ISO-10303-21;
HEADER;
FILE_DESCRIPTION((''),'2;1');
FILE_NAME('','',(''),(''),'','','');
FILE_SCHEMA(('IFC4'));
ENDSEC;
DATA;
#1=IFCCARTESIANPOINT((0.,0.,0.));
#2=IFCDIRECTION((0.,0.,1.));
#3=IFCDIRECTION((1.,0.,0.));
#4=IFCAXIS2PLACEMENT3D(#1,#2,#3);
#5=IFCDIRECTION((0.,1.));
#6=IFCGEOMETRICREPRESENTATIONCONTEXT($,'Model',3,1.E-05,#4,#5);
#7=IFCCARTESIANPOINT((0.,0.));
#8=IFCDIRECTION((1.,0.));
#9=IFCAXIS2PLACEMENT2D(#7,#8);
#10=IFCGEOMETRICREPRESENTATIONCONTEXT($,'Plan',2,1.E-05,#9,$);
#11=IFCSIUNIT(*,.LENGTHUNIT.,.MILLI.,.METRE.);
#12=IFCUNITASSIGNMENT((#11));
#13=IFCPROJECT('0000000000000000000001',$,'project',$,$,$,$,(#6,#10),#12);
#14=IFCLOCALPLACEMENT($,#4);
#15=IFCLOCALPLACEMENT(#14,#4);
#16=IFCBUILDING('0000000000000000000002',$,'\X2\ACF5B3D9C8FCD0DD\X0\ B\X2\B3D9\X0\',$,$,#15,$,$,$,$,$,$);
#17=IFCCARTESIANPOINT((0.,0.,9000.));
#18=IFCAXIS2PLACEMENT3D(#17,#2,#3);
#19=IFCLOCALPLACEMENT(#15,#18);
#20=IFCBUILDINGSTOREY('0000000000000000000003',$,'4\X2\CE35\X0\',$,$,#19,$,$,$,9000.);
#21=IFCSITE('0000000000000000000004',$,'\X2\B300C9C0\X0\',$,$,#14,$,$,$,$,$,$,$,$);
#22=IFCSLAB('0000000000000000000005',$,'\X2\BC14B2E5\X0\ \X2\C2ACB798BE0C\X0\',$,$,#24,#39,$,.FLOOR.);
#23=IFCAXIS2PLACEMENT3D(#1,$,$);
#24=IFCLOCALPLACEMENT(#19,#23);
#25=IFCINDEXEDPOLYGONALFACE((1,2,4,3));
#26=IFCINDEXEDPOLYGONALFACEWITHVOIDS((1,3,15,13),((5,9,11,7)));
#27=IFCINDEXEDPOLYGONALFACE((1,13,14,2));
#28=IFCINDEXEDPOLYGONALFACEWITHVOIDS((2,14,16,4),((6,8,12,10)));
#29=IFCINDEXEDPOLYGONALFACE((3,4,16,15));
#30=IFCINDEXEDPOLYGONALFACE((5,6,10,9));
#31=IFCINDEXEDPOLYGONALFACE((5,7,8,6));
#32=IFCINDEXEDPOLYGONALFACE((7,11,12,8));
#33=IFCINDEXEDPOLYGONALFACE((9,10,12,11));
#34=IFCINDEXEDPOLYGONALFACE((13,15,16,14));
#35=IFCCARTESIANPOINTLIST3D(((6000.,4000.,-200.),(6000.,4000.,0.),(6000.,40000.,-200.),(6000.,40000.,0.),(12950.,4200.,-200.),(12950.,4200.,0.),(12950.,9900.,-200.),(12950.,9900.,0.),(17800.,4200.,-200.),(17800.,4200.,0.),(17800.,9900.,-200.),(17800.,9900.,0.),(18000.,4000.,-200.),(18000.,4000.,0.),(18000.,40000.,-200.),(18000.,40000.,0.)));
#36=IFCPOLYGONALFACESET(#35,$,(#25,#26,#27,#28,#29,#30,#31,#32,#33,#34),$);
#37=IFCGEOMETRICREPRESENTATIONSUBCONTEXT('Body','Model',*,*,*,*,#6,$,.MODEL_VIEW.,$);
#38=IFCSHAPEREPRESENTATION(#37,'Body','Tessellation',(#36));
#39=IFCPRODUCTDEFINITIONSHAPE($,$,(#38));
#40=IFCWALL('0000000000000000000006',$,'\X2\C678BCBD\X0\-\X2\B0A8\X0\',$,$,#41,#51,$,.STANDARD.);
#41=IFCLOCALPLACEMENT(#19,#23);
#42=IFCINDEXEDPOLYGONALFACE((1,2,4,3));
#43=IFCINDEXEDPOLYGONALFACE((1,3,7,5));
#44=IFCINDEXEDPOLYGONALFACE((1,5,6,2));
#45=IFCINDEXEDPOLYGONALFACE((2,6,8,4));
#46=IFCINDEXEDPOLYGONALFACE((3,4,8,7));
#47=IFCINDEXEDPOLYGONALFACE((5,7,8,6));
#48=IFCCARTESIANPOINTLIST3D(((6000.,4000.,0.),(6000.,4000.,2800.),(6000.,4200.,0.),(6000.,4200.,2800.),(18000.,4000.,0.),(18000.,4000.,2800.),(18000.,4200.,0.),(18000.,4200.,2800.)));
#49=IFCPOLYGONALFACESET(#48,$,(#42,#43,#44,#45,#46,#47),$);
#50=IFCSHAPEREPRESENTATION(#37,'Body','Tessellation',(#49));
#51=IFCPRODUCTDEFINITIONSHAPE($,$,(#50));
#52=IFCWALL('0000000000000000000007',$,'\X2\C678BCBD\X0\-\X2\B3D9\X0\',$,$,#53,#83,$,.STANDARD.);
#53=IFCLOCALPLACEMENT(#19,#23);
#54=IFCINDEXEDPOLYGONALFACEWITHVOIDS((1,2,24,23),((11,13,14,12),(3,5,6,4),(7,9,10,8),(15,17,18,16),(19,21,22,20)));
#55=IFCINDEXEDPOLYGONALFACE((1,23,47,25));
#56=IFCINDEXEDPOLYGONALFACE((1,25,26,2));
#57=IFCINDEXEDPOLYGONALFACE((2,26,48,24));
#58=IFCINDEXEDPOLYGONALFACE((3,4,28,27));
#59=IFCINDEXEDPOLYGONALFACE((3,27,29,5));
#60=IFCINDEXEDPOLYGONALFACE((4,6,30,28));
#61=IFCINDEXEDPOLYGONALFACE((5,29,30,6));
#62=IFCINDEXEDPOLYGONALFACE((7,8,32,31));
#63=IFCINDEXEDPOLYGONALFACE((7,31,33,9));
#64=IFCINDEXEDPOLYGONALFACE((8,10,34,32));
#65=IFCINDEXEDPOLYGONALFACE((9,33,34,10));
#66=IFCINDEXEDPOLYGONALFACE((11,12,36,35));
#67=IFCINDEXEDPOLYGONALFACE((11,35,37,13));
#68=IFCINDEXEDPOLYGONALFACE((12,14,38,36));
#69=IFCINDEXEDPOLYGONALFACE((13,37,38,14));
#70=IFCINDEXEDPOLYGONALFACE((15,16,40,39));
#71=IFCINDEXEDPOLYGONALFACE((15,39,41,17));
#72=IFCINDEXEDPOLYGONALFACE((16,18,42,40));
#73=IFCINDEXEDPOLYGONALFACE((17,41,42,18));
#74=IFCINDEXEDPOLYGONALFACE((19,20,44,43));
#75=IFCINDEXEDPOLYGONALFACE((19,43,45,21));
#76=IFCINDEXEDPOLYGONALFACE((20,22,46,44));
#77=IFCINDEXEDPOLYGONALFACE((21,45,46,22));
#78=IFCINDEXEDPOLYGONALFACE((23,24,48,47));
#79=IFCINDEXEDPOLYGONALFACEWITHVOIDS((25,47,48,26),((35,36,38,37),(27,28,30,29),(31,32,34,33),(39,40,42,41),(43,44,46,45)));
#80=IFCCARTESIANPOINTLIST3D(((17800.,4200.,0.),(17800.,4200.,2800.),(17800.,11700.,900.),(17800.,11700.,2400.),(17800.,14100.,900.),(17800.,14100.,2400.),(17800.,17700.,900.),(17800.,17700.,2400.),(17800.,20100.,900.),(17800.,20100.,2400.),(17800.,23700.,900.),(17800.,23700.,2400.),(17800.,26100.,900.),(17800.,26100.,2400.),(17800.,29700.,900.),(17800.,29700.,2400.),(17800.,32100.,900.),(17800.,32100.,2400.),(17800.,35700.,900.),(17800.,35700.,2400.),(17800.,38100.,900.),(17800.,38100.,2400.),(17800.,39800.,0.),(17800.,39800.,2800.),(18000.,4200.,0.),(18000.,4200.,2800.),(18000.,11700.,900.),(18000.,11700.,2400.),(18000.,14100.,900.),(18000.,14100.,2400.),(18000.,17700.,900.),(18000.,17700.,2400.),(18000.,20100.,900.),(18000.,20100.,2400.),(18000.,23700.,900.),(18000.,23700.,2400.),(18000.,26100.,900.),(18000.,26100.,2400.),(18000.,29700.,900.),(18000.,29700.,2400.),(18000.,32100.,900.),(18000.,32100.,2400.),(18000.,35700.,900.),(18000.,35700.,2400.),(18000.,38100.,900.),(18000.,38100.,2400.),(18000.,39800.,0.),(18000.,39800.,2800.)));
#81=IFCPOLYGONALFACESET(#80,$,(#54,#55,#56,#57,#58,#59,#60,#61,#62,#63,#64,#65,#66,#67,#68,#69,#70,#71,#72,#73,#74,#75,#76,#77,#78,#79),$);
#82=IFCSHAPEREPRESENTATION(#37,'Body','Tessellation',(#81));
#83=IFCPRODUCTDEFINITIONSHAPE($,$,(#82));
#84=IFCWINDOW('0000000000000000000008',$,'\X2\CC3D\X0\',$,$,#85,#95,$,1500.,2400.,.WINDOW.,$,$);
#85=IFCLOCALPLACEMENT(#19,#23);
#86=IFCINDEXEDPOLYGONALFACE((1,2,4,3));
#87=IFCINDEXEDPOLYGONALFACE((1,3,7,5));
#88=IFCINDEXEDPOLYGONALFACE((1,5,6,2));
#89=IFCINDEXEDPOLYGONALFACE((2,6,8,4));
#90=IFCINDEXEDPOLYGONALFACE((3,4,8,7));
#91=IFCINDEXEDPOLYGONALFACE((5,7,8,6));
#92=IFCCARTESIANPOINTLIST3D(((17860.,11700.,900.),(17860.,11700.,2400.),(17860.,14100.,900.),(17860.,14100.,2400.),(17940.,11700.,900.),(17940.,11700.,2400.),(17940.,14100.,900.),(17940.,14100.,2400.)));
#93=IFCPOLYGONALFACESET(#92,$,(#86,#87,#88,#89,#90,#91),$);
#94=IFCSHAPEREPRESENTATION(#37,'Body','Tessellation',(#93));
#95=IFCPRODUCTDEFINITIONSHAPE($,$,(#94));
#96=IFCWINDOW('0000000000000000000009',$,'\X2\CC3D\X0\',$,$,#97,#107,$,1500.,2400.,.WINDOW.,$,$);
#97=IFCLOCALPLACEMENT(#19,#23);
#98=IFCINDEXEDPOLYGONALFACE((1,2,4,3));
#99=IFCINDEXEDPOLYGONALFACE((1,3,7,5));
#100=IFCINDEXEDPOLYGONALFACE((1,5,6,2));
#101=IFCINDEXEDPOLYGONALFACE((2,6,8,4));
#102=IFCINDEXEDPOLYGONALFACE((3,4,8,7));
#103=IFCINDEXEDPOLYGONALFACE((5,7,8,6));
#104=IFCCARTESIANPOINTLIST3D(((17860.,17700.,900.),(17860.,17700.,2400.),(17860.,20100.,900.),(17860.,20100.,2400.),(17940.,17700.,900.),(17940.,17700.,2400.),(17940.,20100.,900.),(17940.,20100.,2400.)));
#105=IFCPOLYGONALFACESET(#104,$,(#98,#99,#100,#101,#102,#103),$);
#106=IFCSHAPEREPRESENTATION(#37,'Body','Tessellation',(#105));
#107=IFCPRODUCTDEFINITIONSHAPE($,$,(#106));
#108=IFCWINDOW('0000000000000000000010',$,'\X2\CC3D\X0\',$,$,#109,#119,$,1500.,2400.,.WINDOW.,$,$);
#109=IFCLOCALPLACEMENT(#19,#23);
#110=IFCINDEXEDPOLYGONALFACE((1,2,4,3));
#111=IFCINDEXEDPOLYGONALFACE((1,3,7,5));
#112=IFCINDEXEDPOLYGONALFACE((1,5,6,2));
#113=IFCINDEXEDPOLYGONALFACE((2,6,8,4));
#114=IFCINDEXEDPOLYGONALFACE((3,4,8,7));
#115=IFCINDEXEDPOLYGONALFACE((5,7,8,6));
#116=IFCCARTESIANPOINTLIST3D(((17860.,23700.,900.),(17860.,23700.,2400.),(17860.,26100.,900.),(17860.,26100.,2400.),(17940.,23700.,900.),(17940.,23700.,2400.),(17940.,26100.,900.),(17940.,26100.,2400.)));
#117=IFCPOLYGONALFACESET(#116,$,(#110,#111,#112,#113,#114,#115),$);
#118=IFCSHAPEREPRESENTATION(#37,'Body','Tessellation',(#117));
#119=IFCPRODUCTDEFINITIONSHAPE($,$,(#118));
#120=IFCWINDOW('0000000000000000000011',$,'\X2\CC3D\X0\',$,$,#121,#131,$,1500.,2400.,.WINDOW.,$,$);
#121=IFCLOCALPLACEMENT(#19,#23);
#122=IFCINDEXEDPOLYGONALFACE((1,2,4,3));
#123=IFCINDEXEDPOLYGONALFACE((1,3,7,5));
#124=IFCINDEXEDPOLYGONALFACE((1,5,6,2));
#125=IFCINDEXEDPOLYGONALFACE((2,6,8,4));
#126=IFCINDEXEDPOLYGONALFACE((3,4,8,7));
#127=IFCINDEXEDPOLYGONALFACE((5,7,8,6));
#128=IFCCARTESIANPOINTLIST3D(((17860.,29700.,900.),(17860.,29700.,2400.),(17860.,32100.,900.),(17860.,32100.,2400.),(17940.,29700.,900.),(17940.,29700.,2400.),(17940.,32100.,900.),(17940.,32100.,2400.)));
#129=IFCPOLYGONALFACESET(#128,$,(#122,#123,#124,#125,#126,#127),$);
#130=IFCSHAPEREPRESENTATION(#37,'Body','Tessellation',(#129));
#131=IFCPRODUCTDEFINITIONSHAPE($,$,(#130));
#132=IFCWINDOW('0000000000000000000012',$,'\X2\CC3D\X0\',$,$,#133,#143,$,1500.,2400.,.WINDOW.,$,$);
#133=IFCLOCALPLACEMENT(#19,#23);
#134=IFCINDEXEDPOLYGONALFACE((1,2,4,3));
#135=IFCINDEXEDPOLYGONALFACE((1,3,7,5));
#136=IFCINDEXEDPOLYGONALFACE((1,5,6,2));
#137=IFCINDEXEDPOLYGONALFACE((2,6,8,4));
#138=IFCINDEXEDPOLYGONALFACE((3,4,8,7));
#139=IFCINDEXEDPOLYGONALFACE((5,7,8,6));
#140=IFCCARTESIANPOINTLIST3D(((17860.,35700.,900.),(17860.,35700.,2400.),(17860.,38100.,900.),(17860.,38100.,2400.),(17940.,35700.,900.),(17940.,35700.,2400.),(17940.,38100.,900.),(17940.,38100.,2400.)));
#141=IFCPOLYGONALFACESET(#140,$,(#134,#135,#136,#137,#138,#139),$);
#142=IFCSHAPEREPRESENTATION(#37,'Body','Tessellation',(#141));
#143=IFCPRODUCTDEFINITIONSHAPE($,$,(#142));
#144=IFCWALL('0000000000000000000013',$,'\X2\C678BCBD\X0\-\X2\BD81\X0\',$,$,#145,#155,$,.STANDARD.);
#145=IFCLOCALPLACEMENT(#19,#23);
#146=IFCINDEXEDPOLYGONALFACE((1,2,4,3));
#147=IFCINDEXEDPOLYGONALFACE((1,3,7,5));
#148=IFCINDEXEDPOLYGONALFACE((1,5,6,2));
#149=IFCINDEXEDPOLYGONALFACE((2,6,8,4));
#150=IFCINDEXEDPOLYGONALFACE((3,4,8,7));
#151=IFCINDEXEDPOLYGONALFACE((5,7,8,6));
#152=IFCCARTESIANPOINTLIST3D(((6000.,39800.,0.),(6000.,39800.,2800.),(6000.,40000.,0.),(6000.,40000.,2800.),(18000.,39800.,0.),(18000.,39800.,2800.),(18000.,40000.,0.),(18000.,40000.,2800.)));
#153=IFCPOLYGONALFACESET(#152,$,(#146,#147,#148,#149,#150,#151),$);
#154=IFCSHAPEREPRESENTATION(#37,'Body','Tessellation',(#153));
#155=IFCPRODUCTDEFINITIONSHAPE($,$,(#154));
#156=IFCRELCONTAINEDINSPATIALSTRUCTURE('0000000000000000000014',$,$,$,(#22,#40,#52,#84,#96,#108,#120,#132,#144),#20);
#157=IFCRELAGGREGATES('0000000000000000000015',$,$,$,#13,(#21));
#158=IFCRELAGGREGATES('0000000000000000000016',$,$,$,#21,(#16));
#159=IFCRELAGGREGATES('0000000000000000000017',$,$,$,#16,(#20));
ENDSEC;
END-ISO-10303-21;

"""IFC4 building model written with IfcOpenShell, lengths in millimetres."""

from ifc_helpers import new_model, si_unit, direction, frame, origin_with_axes, origin_2d_with_axis, place, context, subcontext, project, spatial, polyline, outline, extrude, element, fill, save


model = new_model("IFC4")

# Units and contexts
model_context = context("Model", 3, precision=1e-05, world=origin_with_axes(), true_north=direction((0.0, 1.0)))
plan_context = context("Plan", 2, precision=1e-05, world=origin_2d_with_axis())
body_context = subcontext(model_context, "Body", "Model", "MODEL_VIEW")
ifc_project = project(units=[si_unit("LENGTHUNIT", "METRE", prefix="MILLI")], contexts=[model_context, plan_context])

# Site, building, storey
site_placement = place(None, origin_with_axes())
site = spatial("IfcSite", under=ifc_project, at=site_placement, Name="대지")
building_placement = place(site_placement, origin_with_axes())
building = spatial("IfcBuilding", under=site, at=building_placement, Name="공동주택 B동")
storey_placement = place(building_placement, frame((0.0, 0.0, 9000.0), z_axis=(0.0, 0.0, 1.0), x_axis=(1.0, 0.0, 0.0)))
storey = spatial("IfcBuildingStorey", under=building, at=storey_placement, Name="4층", Elevation=9000.0)

# Slab
slab_placement = place(storey_placement, origin_with_axes())
element("IfcSlab", 1, at=slab_placement, inside=storey, Name="바닥 슬래브", PredefinedType="FLOOR", context=body_context, shape_type="SweptSolid", body=[
    extrude(outline(polyline([(6000.0, 4000.0), (18000.0, 4000.0), (18000.0, 40000.0), (6000.0, 40000.0), (6000.0, 4000.0)]), holes=[polyline([(12950.0, 4200.0), (17800.0, 4200.0), (17800.0, 9900.0), (12950.0, 9900.0), (12950.0, 4200.0)])]), frame((0.0, 0.0, -200.0), z_axis=(0.0, 0.0, 1.0), x_axis=(1.0, 0.0, 0.0)), (0.0, 0.0, 1.0), 200.0),
])

# Wall
wall_1_placement = place(storey_placement, origin_with_axes())
element("IfcWall", 2, at=wall_1_placement, inside=storey, Name="외벽-남", PredefinedType="STANDARD", context=body_context, shape_type="SweptSolid", body=[
    extrude(outline(polyline([(6000.0, 4200.0), (18000.0, 4200.0), (18000.0, 4000.0), (6000.0, 4000.0), (6000.0, 4200.0)])), origin_with_axes(), (0.0, 0.0, 1.0), 2800.0),
])

# Wall, openings, windows
wall_2_placement = place(storey_placement, origin_with_axes())
wall_2 = element("IfcWall", 3, at=wall_2_placement, inside=storey, Name="외벽-동", PredefinedType="STANDARD", context=body_context, shape_type="SweptSolid", body=[
    extrude(outline(polyline([(17800.0, 4200.0), (17800.0, 39800.0), (18000.0, 39800.0), (18000.0, 4200.0), (17800.0, 4200.0)])), origin_with_axes(), (0.0, 0.0, 1.0), 2800.0),
])
opening_1_placement = place(storey_placement, origin_with_axes())
opening_1 = element("IfcOpeningElement", 4, at=opening_1_placement, cuts=wall_2, PredefinedType="OPENING", context=body_context, shape_type="SweptSolid", body=[
    extrude(outline(polyline([(18050.0, 11700.0), (18050.0, 14100.0), (17750.0, 14100.0), (17750.0, 11700.0), (18050.0, 11700.0)])), frame((0.0, 0.0, 900.0), z_axis=(0.0, 0.0, 1.0), x_axis=(1.0, 0.0, 0.0)), (0.0, 0.0, 1.0), 1500.0),
])
opening_2_placement = place(storey_placement, origin_with_axes())
opening_2 = element("IfcOpeningElement", 5, at=opening_2_placement, cuts=wall_2, PredefinedType="OPENING", context=body_context, shape_type="SweptSolid", body=[
    extrude(outline(polyline([(18050.0, 17700.0), (18050.0, 20100.0), (17750.0, 20100.0), (17750.0, 17700.0), (18050.0, 17700.0)])), frame((0.0, 0.0, 900.0), z_axis=(0.0, 0.0, 1.0), x_axis=(1.0, 0.0, 0.0)), (0.0, 0.0, 1.0), 1500.0),
])
opening_3_placement = place(storey_placement, origin_with_axes())
opening_3 = element("IfcOpeningElement", 6, at=opening_3_placement, cuts=wall_2, PredefinedType="OPENING", context=body_context, shape_type="SweptSolid", body=[
    extrude(outline(polyline([(18050.0, 23700.0), (18050.0, 26100.0), (17750.0, 26100.0), (17750.0, 23700.0), (18050.0, 23700.0)])), frame((0.0, 0.0, 900.0), z_axis=(0.0, 0.0, 1.0), x_axis=(1.0, 0.0, 0.0)), (0.0, 0.0, 1.0), 1500.0),
])
opening_4_placement = place(storey_placement, origin_with_axes())
opening_4 = element("IfcOpeningElement", 7, at=opening_4_placement, cuts=wall_2, PredefinedType="OPENING", context=body_context, shape_type="SweptSolid", body=[
    extrude(outline(polyline([(18050.0, 29700.0), (18050.0, 32100.0), (17750.0, 32100.0), (17750.0, 29700.0), (18050.0, 29700.0)])), frame((0.0, 0.0, 900.0), z_axis=(0.0, 0.0, 1.0), x_axis=(1.0, 0.0, 0.0)), (0.0, 0.0, 1.0), 1500.0),
])
opening_5_placement = place(storey_placement, origin_with_axes())
opening_5 = element("IfcOpeningElement", 8, at=opening_5_placement, cuts=wall_2, PredefinedType="OPENING", context=body_context, shape_type="SweptSolid", body=[
    extrude(outline(polyline([(18050.0, 35700.0), (18050.0, 38100.0), (17750.0, 38100.0), (17750.0, 35700.0), (18050.0, 35700.0)])), frame((0.0, 0.0, 900.0), z_axis=(0.0, 0.0, 1.0), x_axis=(1.0, 0.0, 0.0)), (0.0, 0.0, 1.0), 1500.0),
])
window_1_placement = place(storey_placement, origin_with_axes())
window_1 = element("IfcWindow", 9, at=window_1_placement, inside=storey, Name="창", OverallHeight=1500.0, OverallWidth=2400.0, PredefinedType="WINDOW", context=body_context, shape_type="SweptSolid", body=[
    extrude(outline(polyline([(17940.0, 11700.0), (17940.0, 14100.0), (17860.0, 14100.0), (17860.0, 11700.0), (17940.0, 11700.0)])), frame((0.0, 0.0, 900.0), z_axis=(0.0, 0.0, 1.0), x_axis=(1.0, 0.0, 0.0)), (0.0, 0.0, 1.0), 1500.0),
])
fill(opening_1, window_1)
window_2_placement = place(storey_placement, origin_with_axes())
window_2 = element("IfcWindow", 10, at=window_2_placement, inside=storey, Name="창", OverallHeight=1500.0, OverallWidth=2400.0, PredefinedType="WINDOW", context=body_context, shape_type="SweptSolid", body=[
    extrude(outline(polyline([(17940.0, 17700.0), (17940.0, 20100.0), (17860.0, 20100.0), (17860.0, 17700.0), (17940.0, 17700.0)])), frame((0.0, 0.0, 900.0), z_axis=(0.0, 0.0, 1.0), x_axis=(1.0, 0.0, 0.0)), (0.0, 0.0, 1.0), 1500.0),
])
fill(opening_2, window_2)
window_3_placement = place(storey_placement, origin_with_axes())
window_3 = element("IfcWindow", 11, at=window_3_placement, inside=storey, Name="창", OverallHeight=1500.0, OverallWidth=2400.0, PredefinedType="WINDOW", context=body_context, shape_type="SweptSolid", body=[
    extrude(outline(polyline([(17940.0, 23700.0), (17940.0, 26100.0), (17860.0, 26100.0), (17860.0, 23700.0), (17940.0, 23700.0)])), frame((0.0, 0.0, 900.0), z_axis=(0.0, 0.0, 1.0), x_axis=(1.0, 0.0, 0.0)), (0.0, 0.0, 1.0), 1500.0),
])
fill(opening_3, window_3)
window_4_placement = place(storey_placement, origin_with_axes())
window_4 = element("IfcWindow", 12, at=window_4_placement, inside=storey, Name="창", OverallHeight=1500.0, OverallWidth=2400.0, PredefinedType="WINDOW", context=body_context, shape_type="SweptSolid", body=[
    extrude(outline(polyline([(17940.0, 29700.0), (17940.0, 32100.0), (17860.0, 32100.0), (17860.0, 29700.0), (17940.0, 29700.0)])), frame((0.0, 0.0, 900.0), z_axis=(0.0, 0.0, 1.0), x_axis=(1.0, 0.0, 0.0)), (0.0, 0.0, 1.0), 1500.0),
])
fill(opening_4, window_4)
window_5_placement = place(storey_placement, origin_with_axes())
window_5 = element("IfcWindow", 13, at=window_5_placement, inside=storey, Name="창", OverallHeight=1500.0, OverallWidth=2400.0, PredefinedType="WINDOW", context=body_context, shape_type="SweptSolid", body=[
    extrude(outline(polyline([(17940.0, 35700.0), (17940.0, 38100.0), (17860.0, 38100.0), (17860.0, 35700.0), (17940.0, 35700.0)])), frame((0.0, 0.0, 900.0), z_axis=(0.0, 0.0, 1.0), x_axis=(1.0, 0.0, 0.0)), (0.0, 0.0, 1.0), 1500.0),
])
fill(opening_5, window_5)

# Wall
wall_3_placement = place(storey_placement, origin_with_axes())
element("IfcWall", 14, at=wall_3_placement, inside=storey, Name="외벽-북", PredefinedType="STANDARD", context=body_context, shape_type="SweptSolid", body=[
    extrude(outline(polyline([(18000.0, 39800.0), (6000.0, 39800.0), (6000.0, 40000.0), (18000.0, 40000.0), (18000.0, 39800.0)])), origin_with_axes(), (0.0, 0.0, 1.0), 2800.0),
])

save(model, "model.ifc")
